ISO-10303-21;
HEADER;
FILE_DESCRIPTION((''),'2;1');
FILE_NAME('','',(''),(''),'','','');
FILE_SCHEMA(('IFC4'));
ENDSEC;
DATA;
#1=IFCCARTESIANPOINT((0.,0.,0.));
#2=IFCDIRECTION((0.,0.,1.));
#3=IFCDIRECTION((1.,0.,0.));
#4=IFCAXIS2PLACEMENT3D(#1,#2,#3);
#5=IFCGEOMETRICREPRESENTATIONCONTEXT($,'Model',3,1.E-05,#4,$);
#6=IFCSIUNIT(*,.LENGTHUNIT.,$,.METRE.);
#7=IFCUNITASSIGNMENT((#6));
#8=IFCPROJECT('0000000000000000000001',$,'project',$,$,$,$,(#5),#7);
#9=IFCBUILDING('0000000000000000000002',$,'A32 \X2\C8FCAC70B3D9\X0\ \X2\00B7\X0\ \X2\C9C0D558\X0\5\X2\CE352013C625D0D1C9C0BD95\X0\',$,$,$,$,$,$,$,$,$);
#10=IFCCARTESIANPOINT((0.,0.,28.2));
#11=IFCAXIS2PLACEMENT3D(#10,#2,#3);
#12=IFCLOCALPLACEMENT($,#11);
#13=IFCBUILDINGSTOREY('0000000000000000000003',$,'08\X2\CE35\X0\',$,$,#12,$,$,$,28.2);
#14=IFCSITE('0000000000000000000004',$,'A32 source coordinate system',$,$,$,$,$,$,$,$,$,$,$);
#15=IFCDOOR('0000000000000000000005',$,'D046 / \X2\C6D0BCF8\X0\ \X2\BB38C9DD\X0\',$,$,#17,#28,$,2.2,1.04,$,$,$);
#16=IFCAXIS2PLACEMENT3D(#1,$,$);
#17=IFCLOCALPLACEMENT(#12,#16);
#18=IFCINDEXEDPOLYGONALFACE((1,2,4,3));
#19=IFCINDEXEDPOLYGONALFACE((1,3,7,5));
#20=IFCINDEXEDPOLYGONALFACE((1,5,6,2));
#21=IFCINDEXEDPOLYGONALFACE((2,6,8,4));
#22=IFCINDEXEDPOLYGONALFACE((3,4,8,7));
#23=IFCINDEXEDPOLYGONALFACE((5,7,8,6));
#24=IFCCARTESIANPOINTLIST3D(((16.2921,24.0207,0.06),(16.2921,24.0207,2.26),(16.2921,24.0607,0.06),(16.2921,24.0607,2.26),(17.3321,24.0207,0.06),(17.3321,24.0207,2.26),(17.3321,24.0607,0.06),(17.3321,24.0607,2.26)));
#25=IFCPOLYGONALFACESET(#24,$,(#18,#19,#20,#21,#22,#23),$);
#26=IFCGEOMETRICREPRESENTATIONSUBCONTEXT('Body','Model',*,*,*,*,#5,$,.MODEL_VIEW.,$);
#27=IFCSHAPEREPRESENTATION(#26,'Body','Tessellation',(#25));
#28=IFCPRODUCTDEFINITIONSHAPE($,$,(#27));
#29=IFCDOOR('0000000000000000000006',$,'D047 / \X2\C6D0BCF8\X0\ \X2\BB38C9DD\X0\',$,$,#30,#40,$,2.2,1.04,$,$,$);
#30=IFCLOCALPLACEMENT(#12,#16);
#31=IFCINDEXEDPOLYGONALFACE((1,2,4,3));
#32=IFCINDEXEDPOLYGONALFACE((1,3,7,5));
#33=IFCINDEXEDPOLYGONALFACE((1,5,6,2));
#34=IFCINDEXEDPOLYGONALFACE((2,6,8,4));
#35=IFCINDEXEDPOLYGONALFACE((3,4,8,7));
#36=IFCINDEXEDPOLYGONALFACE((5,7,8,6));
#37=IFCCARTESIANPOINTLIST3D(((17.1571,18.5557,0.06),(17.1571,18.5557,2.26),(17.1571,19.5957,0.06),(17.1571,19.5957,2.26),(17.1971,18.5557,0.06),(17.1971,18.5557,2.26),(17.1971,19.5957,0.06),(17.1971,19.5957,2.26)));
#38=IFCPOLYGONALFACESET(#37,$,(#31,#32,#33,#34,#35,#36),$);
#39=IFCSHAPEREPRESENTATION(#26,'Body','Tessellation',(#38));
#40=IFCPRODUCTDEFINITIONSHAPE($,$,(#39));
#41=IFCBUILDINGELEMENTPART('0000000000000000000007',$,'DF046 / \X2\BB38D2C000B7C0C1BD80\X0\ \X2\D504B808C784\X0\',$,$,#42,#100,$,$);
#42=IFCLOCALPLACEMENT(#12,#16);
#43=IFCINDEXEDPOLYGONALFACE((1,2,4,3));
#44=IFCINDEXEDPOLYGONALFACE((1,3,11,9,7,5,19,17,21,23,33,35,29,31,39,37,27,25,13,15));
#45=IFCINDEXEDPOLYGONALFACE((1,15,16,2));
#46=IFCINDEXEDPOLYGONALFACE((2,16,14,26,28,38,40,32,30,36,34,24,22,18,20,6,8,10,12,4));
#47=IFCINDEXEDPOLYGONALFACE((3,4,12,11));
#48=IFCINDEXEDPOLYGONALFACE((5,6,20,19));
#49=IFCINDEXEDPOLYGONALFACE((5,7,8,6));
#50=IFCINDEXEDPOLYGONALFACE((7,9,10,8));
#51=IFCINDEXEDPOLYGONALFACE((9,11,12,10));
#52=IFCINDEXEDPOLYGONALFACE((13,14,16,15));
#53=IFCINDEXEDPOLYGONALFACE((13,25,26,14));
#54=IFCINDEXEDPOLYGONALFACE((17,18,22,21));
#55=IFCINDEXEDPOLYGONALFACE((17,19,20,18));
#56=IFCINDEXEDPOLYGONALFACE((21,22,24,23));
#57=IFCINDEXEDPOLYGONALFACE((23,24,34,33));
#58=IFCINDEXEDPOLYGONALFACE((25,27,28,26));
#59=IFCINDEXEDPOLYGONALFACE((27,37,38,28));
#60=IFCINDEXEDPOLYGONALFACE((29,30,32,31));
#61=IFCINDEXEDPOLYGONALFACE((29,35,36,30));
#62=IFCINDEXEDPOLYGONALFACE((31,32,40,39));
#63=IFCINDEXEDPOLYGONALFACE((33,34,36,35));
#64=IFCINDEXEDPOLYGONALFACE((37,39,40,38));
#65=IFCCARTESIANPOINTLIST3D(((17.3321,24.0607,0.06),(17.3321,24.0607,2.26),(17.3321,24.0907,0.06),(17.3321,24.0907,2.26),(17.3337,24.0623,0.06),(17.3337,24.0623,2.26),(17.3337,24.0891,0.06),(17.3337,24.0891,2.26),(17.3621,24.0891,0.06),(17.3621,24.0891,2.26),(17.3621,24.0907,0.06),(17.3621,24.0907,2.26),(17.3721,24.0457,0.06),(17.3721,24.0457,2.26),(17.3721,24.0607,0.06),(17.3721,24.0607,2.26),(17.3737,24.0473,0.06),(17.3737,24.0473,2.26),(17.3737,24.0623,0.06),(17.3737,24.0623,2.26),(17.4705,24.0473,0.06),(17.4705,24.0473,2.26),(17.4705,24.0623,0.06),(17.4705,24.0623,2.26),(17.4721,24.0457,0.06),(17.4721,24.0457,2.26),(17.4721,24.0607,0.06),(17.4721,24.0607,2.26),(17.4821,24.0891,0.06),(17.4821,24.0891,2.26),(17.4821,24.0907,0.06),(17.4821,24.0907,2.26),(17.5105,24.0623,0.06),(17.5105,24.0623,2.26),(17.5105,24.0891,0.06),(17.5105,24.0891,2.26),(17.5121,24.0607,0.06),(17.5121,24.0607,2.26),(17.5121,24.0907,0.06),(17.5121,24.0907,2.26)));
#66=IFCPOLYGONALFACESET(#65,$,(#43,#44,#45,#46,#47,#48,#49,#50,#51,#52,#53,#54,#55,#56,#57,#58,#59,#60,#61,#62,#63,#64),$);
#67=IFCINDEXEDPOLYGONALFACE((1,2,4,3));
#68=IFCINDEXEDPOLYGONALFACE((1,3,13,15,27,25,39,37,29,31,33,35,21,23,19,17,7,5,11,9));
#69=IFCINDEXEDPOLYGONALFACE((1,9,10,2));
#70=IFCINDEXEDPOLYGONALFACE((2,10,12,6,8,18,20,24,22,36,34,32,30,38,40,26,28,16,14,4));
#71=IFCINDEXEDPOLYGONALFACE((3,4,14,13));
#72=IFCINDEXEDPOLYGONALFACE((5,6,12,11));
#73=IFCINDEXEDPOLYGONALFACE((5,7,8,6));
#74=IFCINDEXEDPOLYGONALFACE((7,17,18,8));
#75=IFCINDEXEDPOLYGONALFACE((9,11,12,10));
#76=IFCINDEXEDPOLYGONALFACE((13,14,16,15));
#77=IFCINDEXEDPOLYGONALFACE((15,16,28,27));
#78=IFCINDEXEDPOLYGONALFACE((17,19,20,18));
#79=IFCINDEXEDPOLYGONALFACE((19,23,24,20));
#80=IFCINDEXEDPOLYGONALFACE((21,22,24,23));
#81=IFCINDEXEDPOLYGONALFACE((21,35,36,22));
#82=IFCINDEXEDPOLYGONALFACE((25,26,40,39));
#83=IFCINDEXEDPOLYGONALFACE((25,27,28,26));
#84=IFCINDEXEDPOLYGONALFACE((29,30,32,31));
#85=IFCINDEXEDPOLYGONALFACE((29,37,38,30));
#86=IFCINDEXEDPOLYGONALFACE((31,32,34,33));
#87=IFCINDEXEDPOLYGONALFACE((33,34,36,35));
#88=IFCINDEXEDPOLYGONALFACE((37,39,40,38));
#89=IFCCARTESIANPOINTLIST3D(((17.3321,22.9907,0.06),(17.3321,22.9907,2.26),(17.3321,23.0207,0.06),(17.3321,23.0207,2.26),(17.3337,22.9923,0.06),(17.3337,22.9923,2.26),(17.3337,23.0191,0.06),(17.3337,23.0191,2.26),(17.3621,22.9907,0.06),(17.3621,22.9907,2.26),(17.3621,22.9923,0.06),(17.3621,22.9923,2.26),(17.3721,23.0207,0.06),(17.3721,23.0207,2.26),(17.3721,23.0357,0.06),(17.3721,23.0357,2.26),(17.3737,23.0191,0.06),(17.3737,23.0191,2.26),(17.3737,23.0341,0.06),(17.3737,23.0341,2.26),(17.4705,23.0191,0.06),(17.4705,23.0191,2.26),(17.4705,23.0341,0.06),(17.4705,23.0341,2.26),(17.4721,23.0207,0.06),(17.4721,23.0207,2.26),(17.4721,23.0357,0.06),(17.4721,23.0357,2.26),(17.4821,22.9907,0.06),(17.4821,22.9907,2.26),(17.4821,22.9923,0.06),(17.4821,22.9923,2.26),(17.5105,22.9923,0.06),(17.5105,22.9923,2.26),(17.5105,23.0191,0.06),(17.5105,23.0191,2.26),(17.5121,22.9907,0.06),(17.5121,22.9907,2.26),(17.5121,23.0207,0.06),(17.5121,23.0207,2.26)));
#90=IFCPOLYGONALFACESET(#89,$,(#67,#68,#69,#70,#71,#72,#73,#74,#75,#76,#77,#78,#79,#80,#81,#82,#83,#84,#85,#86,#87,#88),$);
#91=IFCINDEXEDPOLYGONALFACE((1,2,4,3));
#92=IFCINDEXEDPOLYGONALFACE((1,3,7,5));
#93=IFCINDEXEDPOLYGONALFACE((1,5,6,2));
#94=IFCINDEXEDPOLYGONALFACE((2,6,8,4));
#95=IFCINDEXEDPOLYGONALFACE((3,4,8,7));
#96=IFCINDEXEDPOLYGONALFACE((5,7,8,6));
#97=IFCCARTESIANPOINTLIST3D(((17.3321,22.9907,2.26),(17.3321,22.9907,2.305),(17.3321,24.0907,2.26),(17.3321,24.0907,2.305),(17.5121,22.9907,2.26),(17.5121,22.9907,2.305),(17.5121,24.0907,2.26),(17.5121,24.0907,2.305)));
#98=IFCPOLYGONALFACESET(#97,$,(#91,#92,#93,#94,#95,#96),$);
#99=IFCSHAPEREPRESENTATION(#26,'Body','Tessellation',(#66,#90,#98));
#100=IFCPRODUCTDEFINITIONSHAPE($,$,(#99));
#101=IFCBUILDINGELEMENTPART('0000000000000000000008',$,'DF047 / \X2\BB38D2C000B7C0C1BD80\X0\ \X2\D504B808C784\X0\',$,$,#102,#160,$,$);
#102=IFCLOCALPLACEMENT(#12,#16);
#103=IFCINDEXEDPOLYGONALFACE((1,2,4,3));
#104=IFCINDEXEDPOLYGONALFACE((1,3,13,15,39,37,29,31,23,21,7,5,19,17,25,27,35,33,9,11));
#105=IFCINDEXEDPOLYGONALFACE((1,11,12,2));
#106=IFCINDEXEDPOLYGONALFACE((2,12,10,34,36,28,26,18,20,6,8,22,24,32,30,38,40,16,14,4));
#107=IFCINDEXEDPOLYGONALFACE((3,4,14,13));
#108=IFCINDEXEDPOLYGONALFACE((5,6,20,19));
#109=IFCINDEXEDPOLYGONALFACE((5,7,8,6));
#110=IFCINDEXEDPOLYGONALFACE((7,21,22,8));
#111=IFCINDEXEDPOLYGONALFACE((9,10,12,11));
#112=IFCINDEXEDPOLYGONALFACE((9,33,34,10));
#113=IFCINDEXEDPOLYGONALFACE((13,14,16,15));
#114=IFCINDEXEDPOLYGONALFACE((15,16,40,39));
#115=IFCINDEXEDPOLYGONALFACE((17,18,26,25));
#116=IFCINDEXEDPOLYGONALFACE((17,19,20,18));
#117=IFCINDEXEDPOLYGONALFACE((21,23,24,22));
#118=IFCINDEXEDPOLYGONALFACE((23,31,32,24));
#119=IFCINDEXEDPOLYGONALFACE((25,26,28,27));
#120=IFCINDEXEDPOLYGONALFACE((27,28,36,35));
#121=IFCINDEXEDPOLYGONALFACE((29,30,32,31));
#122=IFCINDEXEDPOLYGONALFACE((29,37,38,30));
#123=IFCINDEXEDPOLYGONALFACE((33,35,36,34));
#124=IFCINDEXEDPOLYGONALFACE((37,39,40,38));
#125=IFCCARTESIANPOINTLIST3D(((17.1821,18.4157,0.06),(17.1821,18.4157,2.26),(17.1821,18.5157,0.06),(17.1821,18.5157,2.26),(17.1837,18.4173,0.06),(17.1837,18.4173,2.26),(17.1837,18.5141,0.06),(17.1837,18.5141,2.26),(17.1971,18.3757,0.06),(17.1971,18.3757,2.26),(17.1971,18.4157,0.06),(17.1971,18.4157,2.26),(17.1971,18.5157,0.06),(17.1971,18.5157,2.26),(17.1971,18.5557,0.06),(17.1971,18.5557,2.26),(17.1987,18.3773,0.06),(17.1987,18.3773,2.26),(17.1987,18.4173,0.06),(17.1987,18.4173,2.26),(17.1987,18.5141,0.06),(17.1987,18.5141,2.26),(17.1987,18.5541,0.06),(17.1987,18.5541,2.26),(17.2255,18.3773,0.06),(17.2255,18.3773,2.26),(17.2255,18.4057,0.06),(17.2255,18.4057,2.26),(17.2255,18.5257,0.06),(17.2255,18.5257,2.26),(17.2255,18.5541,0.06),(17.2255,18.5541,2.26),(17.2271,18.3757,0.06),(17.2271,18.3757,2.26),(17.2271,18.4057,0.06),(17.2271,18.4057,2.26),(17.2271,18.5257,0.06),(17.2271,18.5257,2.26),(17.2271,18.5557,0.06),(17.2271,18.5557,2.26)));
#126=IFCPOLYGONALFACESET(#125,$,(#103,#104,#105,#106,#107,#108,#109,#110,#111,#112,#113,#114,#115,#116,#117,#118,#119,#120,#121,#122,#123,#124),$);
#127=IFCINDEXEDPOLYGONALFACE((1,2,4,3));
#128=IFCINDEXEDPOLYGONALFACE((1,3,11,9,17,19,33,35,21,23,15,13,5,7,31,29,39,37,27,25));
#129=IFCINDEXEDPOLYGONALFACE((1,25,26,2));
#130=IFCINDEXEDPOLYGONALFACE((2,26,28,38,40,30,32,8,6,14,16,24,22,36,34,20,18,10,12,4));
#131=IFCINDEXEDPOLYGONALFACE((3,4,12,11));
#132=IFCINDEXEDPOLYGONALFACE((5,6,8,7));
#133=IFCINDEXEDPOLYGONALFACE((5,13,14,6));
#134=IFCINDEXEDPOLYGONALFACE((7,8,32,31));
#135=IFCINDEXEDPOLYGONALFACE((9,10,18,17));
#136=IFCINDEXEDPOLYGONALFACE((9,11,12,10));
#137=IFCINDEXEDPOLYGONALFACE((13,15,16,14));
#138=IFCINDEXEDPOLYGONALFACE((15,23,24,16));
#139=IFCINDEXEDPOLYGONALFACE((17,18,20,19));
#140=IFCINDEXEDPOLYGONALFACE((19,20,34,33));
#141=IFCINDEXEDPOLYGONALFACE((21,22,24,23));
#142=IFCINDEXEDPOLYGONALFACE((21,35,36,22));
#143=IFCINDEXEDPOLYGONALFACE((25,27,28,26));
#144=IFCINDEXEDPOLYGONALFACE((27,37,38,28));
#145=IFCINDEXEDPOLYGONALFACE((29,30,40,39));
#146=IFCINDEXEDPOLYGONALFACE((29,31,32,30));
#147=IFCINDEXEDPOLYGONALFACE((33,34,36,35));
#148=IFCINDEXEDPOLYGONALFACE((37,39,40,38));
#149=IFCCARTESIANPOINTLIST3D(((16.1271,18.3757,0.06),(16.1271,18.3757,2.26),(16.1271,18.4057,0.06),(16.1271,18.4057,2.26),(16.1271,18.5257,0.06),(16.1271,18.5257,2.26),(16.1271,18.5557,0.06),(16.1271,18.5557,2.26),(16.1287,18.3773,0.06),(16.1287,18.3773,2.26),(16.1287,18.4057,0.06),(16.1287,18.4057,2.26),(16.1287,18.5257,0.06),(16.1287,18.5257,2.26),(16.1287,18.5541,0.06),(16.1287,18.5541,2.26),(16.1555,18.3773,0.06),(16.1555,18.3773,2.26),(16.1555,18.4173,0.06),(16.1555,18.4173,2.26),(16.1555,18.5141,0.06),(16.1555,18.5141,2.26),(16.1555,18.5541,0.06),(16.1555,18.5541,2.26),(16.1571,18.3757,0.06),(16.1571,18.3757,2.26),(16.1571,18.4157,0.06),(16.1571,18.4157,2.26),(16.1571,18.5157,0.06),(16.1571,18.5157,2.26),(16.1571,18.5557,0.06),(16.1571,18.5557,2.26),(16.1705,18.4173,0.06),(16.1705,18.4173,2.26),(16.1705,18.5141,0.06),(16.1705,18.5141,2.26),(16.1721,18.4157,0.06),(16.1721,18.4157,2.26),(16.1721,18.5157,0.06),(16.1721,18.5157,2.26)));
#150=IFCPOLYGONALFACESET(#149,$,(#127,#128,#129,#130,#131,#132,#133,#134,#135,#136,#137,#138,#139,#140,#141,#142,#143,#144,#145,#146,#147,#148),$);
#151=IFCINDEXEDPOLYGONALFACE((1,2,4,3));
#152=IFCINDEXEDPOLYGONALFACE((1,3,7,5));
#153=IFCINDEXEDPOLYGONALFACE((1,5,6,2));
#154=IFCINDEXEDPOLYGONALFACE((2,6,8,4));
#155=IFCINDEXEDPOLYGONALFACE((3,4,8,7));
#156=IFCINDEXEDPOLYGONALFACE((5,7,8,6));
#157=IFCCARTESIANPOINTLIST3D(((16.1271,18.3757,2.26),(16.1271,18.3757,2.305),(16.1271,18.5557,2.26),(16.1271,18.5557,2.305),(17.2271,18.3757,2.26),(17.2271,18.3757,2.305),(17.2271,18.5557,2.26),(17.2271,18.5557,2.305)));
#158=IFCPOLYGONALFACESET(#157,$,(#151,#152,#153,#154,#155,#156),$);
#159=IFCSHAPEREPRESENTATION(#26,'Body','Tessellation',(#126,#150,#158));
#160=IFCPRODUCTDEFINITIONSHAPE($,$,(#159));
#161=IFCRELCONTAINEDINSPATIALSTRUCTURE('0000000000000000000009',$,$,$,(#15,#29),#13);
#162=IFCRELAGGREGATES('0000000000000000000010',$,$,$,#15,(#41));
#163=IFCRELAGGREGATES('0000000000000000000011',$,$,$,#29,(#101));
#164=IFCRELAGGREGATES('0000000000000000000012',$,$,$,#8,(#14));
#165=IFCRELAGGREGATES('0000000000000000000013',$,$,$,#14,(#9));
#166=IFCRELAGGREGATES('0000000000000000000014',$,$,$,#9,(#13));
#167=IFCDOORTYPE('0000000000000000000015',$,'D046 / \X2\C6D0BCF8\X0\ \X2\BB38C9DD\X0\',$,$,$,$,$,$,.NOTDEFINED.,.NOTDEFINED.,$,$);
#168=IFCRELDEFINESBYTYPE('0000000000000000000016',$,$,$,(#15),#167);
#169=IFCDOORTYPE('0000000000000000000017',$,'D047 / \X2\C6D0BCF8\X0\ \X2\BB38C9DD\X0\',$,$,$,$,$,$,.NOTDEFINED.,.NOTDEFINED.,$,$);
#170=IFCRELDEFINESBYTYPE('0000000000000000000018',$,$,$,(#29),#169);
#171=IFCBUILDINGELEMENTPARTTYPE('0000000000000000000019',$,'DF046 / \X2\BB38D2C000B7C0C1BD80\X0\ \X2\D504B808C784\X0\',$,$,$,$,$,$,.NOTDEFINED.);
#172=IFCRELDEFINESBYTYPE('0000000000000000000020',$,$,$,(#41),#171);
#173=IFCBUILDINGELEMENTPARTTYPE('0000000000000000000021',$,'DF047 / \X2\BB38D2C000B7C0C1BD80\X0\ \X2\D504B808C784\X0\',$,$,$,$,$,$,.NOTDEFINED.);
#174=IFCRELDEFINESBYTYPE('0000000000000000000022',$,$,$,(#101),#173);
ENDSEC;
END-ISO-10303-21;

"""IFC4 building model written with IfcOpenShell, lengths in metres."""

from ifc_helpers import new_model, si_unit, frame, origin, origin_with_axes, place, context, subcontext, project, spatial, polyline, outline, extrude, source, transform, mapped, type_object, type_shapes, element, aggregate, save


model = new_model("IFC4")

# Units and contexts
model_context = context("Model", 3, precision=1e-05, world=origin_with_axes())
body_context = subcontext(model_context, "Body", "Model", "MODEL_VIEW")
ifc_project = project(units=[si_unit("LENGTHUNIT", "METRE")], contexts=[model_context])

# Site, building, storey
storey_placement = place(None, frame((0.0, 0.0, 28.2), z_axis=(0.0, 0.0, 1.0), x_axis=(1.0, 0.0, 0.0)))
site = spatial("IfcSite", under=ifc_project, Name="A32 source coordinate system")
building = spatial("IfcBuilding", under=site, Name="A32 주거동 · 지하5층–옥탑지붕")
storey = spatial("IfcBuildingStorey", under=building, at=storey_placement, Name="08층", Elevation=28.2)

# Doors
door_type_1 = type_object("IfcDoorType", Name="D046 / 원본 문짝", OperationType="NOTDEFINED", PredefinedType="NOTDEFINED")
shared_shape_1 = source(origin(), body_context, "Body", "SweptSolid", [
    extrude(outline(polyline([(17.3321, 24.0607), (17.3321, 24.0207), (16.2921, 24.0207), (16.2921, 24.0607), (17.3321, 24.0607)])), frame((0.0, 0.0, 0.06)), (0.0, 0.0, 1.0), 2.2),
])
type_shapes(door_type_1, [shared_shape_1])
door_1_placement = place(storey_placement, origin_with_axes())
door_1 = element("IfcDoor", 1, at=door_1_placement, inside=storey, type_object=door_type_1, Name="D046 / 원본 문짝", OverallHeight=2.2, OverallWidth=1.04, context=body_context, shape_type="MappedRepresentation", body=[
    mapped(shared_shape_1, transform((0.0, 0.0, 0.0), scale=1.0)),
])
door_type_2 = type_object("IfcDoorType", Name="D047 / 원본 문짝", OperationType="NOTDEFINED", PredefinedType="NOTDEFINED")
shared_shape_2 = source(origin(), body_context, "Body", "SweptSolid", [
    extrude(outline(polyline([(17.1971, 18.5557), (17.1571, 18.5557), (17.1571, 19.5957), (17.1971, 19.5957), (17.1971, 18.5557)])), frame((0.0, 0.0, 0.06)), (0.0, 0.0, 1.0), 2.2),
])
type_shapes(door_type_2, [shared_shape_2])
door_2_placement = place(storey_placement, origin_with_axes())
door_2 = element("IfcDoor", 2, at=door_2_placement, inside=storey, type_object=door_type_2, Name="D047 / 원본 문짝", OverallHeight=2.2, OverallWidth=1.04, context=body_context, shape_type="MappedRepresentation", body=[
    mapped(shared_shape_2, transform((0.0, 0.0, 0.0), scale=1.0)),
])

# Building element parts
building_element_part_type_1 = type_object("IfcBuildingElementPartType", Name="DF046 / 문틀·상부 프레임", PredefinedType="NOTDEFINED")
shared_shape_3 = source(origin(), body_context, "Body", "SweptSolid", [
    extrude(outline(polyline([(17.3337, 24.0891), (17.3337, 24.0623), (17.3737, 24.0623), (17.3737, 24.0473), (17.4705, 24.0473), (17.4705, 24.0623), (17.5105, 24.0623), (17.5105, 24.0891), (17.4821, 24.0891), (17.4821, 24.0907), (17.5121, 24.0907), (17.5121, 24.0607), (17.4721, 24.0607), (17.4721, 24.0457), (17.3721, 24.0457), (17.3721, 24.0607), (17.3321, 24.0607), (17.3321, 24.0907), (17.3621, 24.0907), (17.3621, 24.0891), (17.3337, 24.0891)])), frame((0.0, 0.0, 0.06)), (0.0, 0.0, 1.0), 2.2),
    extrude(outline(polyline([(17.3621, 22.9907), (17.3321, 22.9907), (17.3321, 23.0207), (17.3721, 23.0207), (17.3721, 23.0357), (17.4721, 23.0357), (17.4721, 23.0207), (17.5121, 23.0207), (17.5121, 22.9907), (17.4821, 22.9907), (17.4821, 22.9923), (17.5105, 22.9923), (17.5105, 23.0191), (17.4705, 23.0191), (17.4705, 23.0341), (17.3737, 23.0341), (17.3737, 23.0191), (17.3337, 23.0191), (17.3337, 22.9923), (17.3621, 22.9923), (17.3621, 22.9907)])), frame((0.0, 0.0, 0.06)), (0.0, 0.0, 1.0), 2.2),
    extrude(outline(polyline([(17.3321, 22.9907), (17.3321, 24.0907), (17.5121, 24.0907), (17.5121, 22.9907), (17.3321, 22.9907)])), frame((0.0, 0.0, 2.26)), (0.0, 0.0, 1.0), 0.045),
])
type_shapes(building_element_part_type_1, [shared_shape_3])
building_element_part_1_placement = place(door_1_placement, origin_with_axes())
building_element_part_1 = element("IfcBuildingElementPart", 3, at=building_element_part_1_placement, type_object=building_element_part_type_1, Name="DF046 / 문틀·상부 프레임", context=body_context, shape_type="MappedRepresentation", body=[
    mapped(shared_shape_3, transform((0.0, 0.0, 0.0), scale=1.0)),
])
aggregate(door_1, [building_element_part_1])
building_element_part_type_2 = type_object("IfcBuildingElementPartType", Name="DF047 / 문틀·상부 프레임", PredefinedType="NOTDEFINED")
shared_shape_4 = source(origin(), body_context, "Body", "SweptSolid", [
    extrude(outline(polyline([(17.2255, 18.5541), (17.1987, 18.5541), (17.1987, 18.5141), (17.1837, 18.5141), (17.1837, 18.4173), (17.1987, 18.4173), (17.1987, 18.3773), (17.2255, 18.3773), (17.2255, 18.4057), (17.2271, 18.4057), (17.2271, 18.3757), (17.1971, 18.3757), (17.1971, 18.4157), (17.1821, 18.4157), (17.1821, 18.5157), (17.1971, 18.5157), (17.1971, 18.5557), (17.2271, 18.5557), (17.2271, 18.5257), (17.2255, 18.5257), (17.2255, 18.5541)])), frame((0.0, 0.0, 0.06)), (0.0, 0.0, 1.0), 2.2),
    extrude(outline(polyline([(16.1271, 18.5257), (16.1271, 18.5557), (16.1571, 18.5557), (16.1571, 18.5157), (16.1721, 18.5157), (16.1721, 18.4157), (16.1571, 18.4157), (16.1571, 18.3757), (16.1271, 18.3757), (16.1271, 18.4057), (16.1287, 18.4057), (16.1287, 18.3773), (16.1555, 18.3773), (16.1555, 18.4173), (16.1705, 18.4173), (16.1705, 18.5141), (16.1555, 18.5141), (16.1555, 18.5541), (16.1287, 18.5541), (16.1287, 18.5257), (16.1271, 18.5257)])), frame((0.0, 0.0, 0.06)), (0.0, 0.0, 1.0), 2.2),
    extrude(outline(polyline([(16.1271, 18.3757), (16.1271, 18.5557), (17.2271, 18.5557), (17.2271, 18.3757), (16.1271, 18.3757)])), frame((0.0, 0.0, 2.26)), (0.0, 0.0, 1.0), 0.045),
])
type_shapes(building_element_part_type_2, [shared_shape_4])
building_element_part_2_placement = place(door_2_placement, origin_with_axes())
building_element_part_2 = element("IfcBuildingElementPart", 4, at=building_element_part_2_placement, type_object=building_element_part_type_2, Name="DF047 / 문틀·상부 프레임", context=body_context, shape_type="MappedRepresentation", body=[
    mapped(shared_shape_4, transform((0.0, 0.0, 0.0), scale=1.0)),
])
aggregate(door_2, [building_element_part_2])

save(model, "model.ifc")
